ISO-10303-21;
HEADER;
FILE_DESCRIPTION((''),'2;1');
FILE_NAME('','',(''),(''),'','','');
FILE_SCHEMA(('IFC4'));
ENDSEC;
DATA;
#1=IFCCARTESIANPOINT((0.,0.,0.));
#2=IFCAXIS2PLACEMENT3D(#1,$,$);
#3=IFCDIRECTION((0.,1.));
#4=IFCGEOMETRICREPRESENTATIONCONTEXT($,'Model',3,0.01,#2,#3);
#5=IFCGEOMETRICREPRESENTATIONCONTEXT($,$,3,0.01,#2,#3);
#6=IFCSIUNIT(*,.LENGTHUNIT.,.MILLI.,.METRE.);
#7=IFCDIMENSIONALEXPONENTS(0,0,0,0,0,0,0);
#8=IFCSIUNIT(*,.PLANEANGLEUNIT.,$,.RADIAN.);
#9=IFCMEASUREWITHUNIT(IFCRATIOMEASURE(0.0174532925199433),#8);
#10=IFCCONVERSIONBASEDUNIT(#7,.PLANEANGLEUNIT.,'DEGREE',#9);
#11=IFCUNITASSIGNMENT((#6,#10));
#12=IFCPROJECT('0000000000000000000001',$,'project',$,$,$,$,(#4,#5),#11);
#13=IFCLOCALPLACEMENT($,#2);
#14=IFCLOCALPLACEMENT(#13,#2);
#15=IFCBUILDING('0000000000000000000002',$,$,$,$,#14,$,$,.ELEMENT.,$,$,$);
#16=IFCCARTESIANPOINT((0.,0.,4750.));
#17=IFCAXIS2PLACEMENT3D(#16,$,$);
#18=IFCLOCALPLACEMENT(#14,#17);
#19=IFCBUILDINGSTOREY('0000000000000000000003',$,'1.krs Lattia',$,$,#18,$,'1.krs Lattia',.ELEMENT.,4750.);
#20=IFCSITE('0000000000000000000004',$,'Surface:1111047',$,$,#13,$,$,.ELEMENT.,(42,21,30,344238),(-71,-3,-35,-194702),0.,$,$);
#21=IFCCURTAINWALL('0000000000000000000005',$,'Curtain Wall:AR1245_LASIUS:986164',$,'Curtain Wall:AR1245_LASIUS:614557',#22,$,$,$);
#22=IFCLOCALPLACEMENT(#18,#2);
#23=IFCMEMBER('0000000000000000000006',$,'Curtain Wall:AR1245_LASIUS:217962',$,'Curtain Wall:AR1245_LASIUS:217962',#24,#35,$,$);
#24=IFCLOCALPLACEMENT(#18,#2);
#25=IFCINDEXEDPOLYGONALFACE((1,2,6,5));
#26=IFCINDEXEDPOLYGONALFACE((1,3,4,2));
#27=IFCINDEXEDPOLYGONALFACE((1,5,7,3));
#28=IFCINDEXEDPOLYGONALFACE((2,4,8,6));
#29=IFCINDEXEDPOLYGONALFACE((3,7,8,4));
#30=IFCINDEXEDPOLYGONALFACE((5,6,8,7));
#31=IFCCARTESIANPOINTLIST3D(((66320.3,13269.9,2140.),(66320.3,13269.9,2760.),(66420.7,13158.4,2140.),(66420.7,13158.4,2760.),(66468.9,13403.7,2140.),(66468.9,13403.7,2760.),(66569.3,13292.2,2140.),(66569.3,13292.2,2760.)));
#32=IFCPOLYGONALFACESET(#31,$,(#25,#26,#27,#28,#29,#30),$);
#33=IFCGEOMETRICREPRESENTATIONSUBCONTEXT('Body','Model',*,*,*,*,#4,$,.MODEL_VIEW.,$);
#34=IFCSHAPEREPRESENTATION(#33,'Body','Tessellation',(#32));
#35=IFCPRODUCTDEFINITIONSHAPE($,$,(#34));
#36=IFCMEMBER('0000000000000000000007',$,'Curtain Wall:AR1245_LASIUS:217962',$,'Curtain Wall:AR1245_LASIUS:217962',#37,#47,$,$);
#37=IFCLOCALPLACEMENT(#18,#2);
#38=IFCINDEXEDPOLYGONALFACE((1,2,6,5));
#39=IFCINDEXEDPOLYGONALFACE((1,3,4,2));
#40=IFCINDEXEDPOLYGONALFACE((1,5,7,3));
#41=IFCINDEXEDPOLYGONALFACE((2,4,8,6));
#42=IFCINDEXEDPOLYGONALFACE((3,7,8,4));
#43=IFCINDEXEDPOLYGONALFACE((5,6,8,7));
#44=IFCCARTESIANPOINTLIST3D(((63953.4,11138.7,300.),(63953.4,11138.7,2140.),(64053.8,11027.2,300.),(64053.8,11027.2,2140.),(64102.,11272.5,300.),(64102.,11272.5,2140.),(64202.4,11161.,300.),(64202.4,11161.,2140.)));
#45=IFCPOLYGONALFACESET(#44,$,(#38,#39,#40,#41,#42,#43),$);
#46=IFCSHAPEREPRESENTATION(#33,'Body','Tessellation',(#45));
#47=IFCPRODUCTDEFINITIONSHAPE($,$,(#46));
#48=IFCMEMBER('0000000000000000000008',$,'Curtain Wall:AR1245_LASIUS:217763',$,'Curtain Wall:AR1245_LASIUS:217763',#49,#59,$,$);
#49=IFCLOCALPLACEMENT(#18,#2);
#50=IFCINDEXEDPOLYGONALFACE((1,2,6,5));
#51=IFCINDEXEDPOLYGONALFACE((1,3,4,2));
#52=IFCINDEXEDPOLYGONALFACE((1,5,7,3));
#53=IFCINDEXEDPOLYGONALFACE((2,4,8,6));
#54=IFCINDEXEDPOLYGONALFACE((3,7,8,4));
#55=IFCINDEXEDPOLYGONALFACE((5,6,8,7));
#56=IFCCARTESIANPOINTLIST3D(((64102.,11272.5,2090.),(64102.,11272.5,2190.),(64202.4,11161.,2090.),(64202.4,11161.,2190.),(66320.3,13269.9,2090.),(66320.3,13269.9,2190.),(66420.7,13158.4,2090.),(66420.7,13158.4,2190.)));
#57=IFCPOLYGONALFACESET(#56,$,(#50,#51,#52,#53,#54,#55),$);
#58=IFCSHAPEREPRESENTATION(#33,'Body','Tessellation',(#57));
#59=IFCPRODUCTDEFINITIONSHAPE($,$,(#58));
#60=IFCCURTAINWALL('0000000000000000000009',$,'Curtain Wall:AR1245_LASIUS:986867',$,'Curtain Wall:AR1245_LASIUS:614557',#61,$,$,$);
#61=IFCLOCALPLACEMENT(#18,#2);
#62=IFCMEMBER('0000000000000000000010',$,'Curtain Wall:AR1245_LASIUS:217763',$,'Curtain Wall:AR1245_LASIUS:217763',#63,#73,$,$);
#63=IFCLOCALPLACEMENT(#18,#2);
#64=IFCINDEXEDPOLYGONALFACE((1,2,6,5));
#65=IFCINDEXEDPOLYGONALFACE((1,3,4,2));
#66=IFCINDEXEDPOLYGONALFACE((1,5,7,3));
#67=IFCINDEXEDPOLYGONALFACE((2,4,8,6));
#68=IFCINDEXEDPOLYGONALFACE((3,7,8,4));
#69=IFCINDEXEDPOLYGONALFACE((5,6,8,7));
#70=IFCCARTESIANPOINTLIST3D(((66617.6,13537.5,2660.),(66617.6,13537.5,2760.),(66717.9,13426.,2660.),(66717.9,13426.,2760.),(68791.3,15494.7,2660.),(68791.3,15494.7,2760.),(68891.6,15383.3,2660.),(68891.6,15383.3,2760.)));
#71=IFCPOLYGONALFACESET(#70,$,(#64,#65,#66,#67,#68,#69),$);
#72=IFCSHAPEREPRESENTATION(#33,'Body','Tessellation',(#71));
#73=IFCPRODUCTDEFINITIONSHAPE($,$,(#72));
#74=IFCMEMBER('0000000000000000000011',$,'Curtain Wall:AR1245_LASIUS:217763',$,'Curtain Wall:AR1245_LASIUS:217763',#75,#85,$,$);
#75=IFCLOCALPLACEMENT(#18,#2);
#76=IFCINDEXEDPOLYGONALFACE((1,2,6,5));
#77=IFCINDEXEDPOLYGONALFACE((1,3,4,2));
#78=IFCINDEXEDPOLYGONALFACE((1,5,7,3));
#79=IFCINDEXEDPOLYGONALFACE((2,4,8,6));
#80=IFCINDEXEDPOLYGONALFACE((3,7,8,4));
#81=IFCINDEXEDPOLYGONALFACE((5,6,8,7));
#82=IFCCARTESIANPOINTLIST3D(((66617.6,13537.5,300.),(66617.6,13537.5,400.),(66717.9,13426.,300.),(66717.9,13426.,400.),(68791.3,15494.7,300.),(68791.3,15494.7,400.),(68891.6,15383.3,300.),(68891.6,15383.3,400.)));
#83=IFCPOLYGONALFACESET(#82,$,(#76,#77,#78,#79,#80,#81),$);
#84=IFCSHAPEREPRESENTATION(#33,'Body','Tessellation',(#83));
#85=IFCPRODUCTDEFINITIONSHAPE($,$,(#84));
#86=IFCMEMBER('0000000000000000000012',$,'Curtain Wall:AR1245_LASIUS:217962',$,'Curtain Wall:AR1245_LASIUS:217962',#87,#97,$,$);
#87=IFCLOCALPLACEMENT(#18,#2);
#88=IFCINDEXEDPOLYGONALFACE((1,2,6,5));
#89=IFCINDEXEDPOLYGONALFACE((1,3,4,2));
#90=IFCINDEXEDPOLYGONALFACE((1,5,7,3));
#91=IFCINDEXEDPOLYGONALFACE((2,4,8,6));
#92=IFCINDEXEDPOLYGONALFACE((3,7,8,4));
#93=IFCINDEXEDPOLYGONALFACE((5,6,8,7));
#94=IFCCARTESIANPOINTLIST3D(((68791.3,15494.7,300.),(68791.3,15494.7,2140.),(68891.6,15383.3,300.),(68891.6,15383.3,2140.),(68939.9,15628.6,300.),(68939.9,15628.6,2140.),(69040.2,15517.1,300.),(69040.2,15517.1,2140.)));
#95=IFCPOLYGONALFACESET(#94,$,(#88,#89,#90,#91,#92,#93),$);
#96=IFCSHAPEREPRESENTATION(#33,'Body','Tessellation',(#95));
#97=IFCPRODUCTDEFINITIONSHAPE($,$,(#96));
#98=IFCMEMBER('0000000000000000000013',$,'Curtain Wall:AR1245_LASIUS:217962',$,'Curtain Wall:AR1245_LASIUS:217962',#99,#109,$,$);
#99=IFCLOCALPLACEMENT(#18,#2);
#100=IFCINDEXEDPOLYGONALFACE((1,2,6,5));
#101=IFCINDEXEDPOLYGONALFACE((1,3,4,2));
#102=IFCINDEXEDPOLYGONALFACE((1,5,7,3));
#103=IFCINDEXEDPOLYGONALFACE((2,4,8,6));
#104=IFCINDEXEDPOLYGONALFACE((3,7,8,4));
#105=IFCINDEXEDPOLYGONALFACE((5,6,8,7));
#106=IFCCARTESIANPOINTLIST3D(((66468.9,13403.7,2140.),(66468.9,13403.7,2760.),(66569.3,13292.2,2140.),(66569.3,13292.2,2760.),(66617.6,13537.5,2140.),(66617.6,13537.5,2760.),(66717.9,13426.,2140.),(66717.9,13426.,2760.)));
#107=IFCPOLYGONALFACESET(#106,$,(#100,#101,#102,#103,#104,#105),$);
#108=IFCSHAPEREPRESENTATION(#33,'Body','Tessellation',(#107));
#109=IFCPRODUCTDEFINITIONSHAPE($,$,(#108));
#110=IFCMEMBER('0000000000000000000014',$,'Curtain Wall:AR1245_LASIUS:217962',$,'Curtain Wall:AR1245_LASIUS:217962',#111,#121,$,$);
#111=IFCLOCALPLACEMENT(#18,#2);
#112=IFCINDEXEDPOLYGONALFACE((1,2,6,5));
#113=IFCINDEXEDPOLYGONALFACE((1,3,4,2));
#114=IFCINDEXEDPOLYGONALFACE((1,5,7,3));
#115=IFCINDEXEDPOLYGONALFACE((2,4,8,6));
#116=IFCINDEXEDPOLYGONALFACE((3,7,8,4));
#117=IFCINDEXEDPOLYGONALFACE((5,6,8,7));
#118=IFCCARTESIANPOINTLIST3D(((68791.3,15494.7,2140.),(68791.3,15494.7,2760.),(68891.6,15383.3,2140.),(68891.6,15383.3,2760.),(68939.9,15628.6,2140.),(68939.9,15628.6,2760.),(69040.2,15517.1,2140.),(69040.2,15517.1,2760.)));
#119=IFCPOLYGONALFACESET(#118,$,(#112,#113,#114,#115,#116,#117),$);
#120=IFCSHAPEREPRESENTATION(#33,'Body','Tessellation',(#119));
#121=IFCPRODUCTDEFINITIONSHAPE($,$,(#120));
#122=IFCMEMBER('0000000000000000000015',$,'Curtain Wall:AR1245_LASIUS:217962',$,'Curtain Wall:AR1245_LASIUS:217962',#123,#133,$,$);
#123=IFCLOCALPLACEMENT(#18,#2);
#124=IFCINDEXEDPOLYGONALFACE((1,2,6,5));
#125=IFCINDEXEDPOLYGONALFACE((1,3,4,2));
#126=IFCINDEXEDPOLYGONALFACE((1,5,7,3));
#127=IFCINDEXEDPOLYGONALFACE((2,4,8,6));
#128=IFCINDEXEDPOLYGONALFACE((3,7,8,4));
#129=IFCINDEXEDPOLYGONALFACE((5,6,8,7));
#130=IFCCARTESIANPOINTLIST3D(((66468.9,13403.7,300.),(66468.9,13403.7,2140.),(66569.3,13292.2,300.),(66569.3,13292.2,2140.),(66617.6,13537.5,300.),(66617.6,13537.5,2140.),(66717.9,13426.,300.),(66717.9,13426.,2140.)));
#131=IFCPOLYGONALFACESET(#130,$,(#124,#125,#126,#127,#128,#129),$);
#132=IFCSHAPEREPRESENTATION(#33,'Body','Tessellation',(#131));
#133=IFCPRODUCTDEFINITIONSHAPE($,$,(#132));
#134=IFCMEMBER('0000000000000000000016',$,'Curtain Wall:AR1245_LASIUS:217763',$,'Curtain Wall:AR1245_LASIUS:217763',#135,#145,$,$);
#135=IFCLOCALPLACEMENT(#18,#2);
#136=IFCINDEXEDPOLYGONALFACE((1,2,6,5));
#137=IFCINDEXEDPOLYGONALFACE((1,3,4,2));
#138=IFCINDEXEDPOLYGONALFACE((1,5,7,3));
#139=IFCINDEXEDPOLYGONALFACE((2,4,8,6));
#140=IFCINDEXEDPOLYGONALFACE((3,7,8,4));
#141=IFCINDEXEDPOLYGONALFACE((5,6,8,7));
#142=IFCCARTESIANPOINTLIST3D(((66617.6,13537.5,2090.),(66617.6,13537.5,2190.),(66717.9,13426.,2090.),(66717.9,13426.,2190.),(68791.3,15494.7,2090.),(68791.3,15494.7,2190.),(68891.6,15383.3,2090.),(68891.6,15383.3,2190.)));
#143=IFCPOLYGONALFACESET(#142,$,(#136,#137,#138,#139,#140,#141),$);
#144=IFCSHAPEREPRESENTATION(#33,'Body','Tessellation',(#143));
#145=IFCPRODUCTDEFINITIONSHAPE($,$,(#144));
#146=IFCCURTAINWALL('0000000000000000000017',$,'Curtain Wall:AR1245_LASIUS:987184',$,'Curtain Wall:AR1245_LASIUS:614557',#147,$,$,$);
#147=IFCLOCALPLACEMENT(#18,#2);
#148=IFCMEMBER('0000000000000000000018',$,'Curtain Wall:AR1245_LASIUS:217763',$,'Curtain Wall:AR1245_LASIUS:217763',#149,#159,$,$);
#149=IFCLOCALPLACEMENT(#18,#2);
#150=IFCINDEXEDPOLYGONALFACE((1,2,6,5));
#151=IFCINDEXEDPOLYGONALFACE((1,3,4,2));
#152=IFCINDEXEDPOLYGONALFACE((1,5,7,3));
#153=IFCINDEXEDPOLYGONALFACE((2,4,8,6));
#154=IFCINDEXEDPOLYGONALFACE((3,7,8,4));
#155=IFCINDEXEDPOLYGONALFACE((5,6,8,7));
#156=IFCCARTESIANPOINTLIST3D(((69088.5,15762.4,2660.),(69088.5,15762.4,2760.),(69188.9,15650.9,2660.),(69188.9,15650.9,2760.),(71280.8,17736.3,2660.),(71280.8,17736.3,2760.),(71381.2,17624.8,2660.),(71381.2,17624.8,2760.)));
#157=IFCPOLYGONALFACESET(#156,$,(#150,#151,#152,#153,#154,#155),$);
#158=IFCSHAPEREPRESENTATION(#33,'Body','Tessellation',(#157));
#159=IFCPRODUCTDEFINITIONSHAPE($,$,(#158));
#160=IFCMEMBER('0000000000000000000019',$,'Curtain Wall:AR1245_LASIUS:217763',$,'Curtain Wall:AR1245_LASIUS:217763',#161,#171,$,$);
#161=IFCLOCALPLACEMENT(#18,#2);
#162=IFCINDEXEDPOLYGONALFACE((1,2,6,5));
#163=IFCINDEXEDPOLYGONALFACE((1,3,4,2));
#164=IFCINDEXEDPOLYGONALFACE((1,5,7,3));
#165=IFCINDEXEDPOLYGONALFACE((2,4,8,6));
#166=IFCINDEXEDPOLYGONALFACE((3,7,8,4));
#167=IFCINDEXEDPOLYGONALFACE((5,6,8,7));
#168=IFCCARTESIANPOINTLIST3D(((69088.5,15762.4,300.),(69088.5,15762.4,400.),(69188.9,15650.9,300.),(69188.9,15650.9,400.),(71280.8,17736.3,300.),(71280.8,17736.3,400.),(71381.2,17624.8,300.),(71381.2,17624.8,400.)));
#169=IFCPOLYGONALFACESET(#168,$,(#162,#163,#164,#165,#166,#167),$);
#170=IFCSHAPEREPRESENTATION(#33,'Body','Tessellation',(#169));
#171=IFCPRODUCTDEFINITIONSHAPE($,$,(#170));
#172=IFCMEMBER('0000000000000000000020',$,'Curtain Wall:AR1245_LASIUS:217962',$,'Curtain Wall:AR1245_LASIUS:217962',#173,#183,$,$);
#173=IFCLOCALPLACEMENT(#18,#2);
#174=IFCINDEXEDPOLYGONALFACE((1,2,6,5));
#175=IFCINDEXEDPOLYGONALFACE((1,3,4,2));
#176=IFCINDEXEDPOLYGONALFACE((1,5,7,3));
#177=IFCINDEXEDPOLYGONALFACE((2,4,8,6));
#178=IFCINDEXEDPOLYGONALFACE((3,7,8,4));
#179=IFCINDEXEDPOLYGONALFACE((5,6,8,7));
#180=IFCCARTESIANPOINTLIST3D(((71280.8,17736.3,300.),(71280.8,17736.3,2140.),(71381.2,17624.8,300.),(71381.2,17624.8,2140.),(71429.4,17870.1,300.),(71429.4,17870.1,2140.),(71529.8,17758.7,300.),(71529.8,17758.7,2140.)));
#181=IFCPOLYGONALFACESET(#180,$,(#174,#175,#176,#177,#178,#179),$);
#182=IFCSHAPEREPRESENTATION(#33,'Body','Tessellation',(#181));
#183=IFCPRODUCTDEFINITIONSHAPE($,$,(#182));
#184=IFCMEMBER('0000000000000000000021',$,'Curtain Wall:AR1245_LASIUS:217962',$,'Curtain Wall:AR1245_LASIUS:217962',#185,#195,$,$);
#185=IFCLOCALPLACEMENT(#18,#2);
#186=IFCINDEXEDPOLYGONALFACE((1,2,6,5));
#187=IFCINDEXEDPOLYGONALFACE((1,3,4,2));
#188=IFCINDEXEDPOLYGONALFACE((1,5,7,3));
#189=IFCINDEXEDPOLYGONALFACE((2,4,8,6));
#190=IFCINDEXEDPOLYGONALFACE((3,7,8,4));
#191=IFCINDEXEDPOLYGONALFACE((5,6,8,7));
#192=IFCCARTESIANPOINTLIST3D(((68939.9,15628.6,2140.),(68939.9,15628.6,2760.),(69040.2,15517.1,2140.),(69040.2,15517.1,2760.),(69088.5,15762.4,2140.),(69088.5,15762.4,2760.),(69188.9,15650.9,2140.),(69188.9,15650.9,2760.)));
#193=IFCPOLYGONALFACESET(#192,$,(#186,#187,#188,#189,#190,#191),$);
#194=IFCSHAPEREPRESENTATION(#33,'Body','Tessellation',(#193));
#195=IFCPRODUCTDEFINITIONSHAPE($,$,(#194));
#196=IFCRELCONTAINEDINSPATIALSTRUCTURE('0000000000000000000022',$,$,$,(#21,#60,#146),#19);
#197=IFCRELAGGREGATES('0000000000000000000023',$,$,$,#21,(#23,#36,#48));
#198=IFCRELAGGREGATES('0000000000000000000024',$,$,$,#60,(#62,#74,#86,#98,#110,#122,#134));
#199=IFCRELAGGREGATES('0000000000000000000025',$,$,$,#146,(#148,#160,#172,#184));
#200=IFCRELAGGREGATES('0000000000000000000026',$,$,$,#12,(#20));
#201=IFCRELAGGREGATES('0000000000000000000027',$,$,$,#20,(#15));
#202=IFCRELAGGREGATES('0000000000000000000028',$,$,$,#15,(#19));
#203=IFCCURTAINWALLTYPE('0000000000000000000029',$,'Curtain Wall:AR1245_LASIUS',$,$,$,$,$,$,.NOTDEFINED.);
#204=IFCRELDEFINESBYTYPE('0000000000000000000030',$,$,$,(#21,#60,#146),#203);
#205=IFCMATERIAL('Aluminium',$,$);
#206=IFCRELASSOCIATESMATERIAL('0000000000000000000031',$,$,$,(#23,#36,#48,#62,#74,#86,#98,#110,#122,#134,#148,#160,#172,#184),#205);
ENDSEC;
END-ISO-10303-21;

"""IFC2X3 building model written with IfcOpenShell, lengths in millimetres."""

from ifc_helpers import new_model, entity, si_unit, converted_unit, direction, frame, frame_2d, origin, place, context, subcontext, project, spatial, rectangle, extrude, material, type_object, element, aggregate, save


model = new_model("IFC2X3")

# Units and contexts
model_context = context("Model", 3, precision=0.01, world=origin(), true_north=direction((0.0, 1.0)))
context_of_model = context(None, 3, precision=0.01, world=origin(), true_north=direction((0.0, 1.0)))
body_context = subcontext(model_context, "Body", "Model", "MODEL_VIEW")
ifc_project = project(units=[si_unit("LENGTHUNIT", "METRE", prefix="MILLI"), converted_unit("PLANEANGLEUNIT", "DEGREE", entity("IfcRatioMeasure", 0.0174532925199433), si_unit("PLANEANGLEUNIT", "RADIAN"), dimensions=[0, 0, 0, 0, 0, 0, 0])], contexts=[model_context, context_of_model])

# Site, building, storey
site_placement = place(None, origin())
site = spatial("IfcSite", under=ifc_project, at=site_placement, Name="Surface:1111047", CompositionType="ELEMENT", RefLatitude=(42, 21, 30, 344238), RefLongitude=(-71, -3, -35, -194702), RefElevation=0.0)
building_placement = place(site_placement, origin())
building = spatial("IfcBuilding", under=site, at=building_placement, CompositionType="ELEMENT")
storey_placement = place(building_placement, frame((0.0, 0.0, 4750.0)))
storey = spatial("IfcBuildingStorey", under=building, at=storey_placement, Name="1.krs Lattia", LongName="1.krs Lattia", CompositionType="ELEMENT", Elevation=4750.0)

# Curtain walls, members
curtain_wall_type_1 = type_object("IfcCurtainWallType", Name="Curtain Wall:AR1245_LASIUS", PredefinedType="NOTDEFINED")
curtain_wall_1_placement = place(storey_placement, frame((0.0, 0.0, -4750.0)))
curtain_wall_1 = element("IfcCurtainWall", 1, at=curtain_wall_1_placement, inside=storey, type_object=curtain_wall_type_1, Name="Curtain Wall:AR1245_LASIUS:986164", ObjectType="Curtain Wall:AR1245_LASIUS:614557")
ifc_material_1 = material(Name="Aluminium")
member_1_placement = place(curtain_wall_1_placement, frame((0.0, 0.0, 4750.0)))
member_1 = element("IfcMember", 2, at=member_1_placement, material=ifc_material_1, Name="Curtain Wall:AR1245_LASIUS:217962", ObjectType="Curtain Wall:AR1245_LASIUS:217962", context=body_context, shape_type="SweptSolid", body=[
    extrude(rectangle(XDim=200.0, YDim=150.0, at=frame_2d((0.0, 0.0), x_axis=(1.0, 0.0))), frame((66444.8, 13281.0, 2140.0), z_axis=(0.0, 0.0, 1.0), x_axis=(0.743145, 0.669131, 0.0)), (0.0, 0.0, 1.0), 620.0),
])
member_2_placement = place(curtain_wall_1_placement, frame((0.0, 0.0, 4750.0)))
member_2 = element("IfcMember", 3, at=member_2_placement, material=ifc_material_1, Name="Curtain Wall:AR1245_LASIUS:217962", ObjectType="Curtain Wall:AR1245_LASIUS:217962", context=body_context, shape_type="SweptSolid", body=[
    extrude(rectangle(XDim=150.0, YDim=200.0, at=frame_2d((0.0, 0.0), x_axis=(1.0, 0.0))), frame((64077.9, 11149.9, 2140.0), z_axis=(0.0, 0.0, -1.0), x_axis=(0.669131, -0.743145, 0.0)), (0.0, 0.0, 1.0), 1840.0),
])
member_3_placement = place(curtain_wall_1_placement, frame((0.0, 0.0, 4750.0)))
member_3 = element("IfcMember", 4, at=member_3_placement, material=ifc_material_1, Name="Curtain Wall:AR1245_LASIUS:217763", ObjectType="Curtain Wall:AR1245_LASIUS:217763", context=body_context, shape_type="SweptSolid", body=[
    extrude(rectangle(XDim=100.0, YDim=150.0, at=frame_2d((0.0, 0.0), x_axis=(1.0, 0.0))), frame((66370.5, 13214.1, 2140.0), z_axis=(-0.743145, -0.669131, 0.0), x_axis=(0.0, 0.0, -1.0)), (0.0, 0.0, 1.0), 2985.0),
])
aggregate(curtain_wall_1, [member_1, member_2, member_3])
curtain_wall_2_placement = place(storey_placement, frame((0.0, 0.0, -4750.0)))
curtain_wall_2 = element("IfcCurtainWall", 5, at=curtain_wall_2_placement, inside=storey, type_object=curtain_wall_type_1, Name="Curtain Wall:AR1245_LASIUS:986867", ObjectType="Curtain Wall:AR1245_LASIUS:614557")
member_4_placement = place(curtain_wall_2_placement, frame((0.0, 0.0, 4750.0)))
member_4 = element("IfcMember", 6, at=member_4_placement, material=ifc_material_1, Name="Curtain Wall:AR1245_LASIUS:217763", ObjectType="Curtain Wall:AR1245_LASIUS:217763", context=body_context, shape_type="SweptSolid", body=[
    extrude(rectangle(XDim=100.0, YDim=150.0, at=frame_2d((0.0, 0.0), x_axis=(1.0, 0.0))), frame((68841.4, 15439.0, 2710.0), z_axis=(-0.743145, -0.669131, 0.0), x_axis=(0.0, 0.0, -1.0)), (0.0, 0.0, 1.0), 2925.0),
])
member_5_placement = place(curtain_wall_2_placement, frame((0.0, 0.0, 4750.0)))
member_5 = element("IfcMember", 7, at=member_5_placement, material=ifc_material_1, Name="Curtain Wall:AR1245_LASIUS:217763", ObjectType="Curtain Wall:AR1245_LASIUS:217763", context=body_context, shape_type="SweptSolid", body=[
    extrude(rectangle(XDim=100.0, YDim=150.0, at=frame_2d((0.0, 0.0), x_axis=(1.0, 0.0))), frame((66667.7, 13481.8, 350.0), z_axis=(0.743145, 0.669131, 0.0), x_axis=(0.0, 0.0, -1.0)), (0.0, 0.0, 1.0), 2925.0),
])
member_6_placement = place(curtain_wall_2_placement, frame((0.0, 0.0, 4750.0)))
member_6 = element("IfcMember", 8, at=member_6_placement, material=ifc_material_1, Name="Curtain Wall:AR1245_LASIUS:217962", ObjectType="Curtain Wall:AR1245_LASIUS:217962", context=body_context, shape_type="SweptSolid", body=[
    extrude(rectangle(XDim=200.0, YDim=150.0, at=frame_2d((0.0, 0.0), x_axis=(1.0, 0.0))), frame((68915.7, 15505.9, 300.0), z_axis=(0.0, 0.0, 1.0), x_axis=(0.743145, 0.669131, 0.0)), (0.0, 0.0, 1.0), 1840.0),
])
member_7_placement = place(curtain_wall_2_placement, frame((0.0, 0.0, 4750.0)))
member_7 = element("IfcMember", 9, at=member_7_placement, material=ifc_material_1, Name="Curtain Wall:AR1245_LASIUS:217962", ObjectType="Curtain Wall:AR1245_LASIUS:217962", context=body_context, shape_type="SweptSolid", body=[
    extrude(rectangle(XDim=150.0, YDim=200.0, at=frame_2d((0.0, 0.0), x_axis=(1.0, 0.0))), frame((66593.4, 13414.9, 2760.0), z_axis=(0.0, 0.0, -1.0), x_axis=(0.669131, -0.743145, 0.0)), (0.0, 0.0, 1.0), 620.0),
])
member_8_placement = place(curtain_wall_2_placement, frame((0.0, 0.0, 4750.0)))
member_8 = element("IfcMember", 10, at=member_8_placement, material=ifc_material_1, Name="Curtain Wall:AR1245_LASIUS:217962", ObjectType="Curtain Wall:AR1245_LASIUS:217962", context=body_context, shape_type="SweptSolid", body=[
    extrude(rectangle(XDim=200.0, YDim=150.0, at=frame_2d((0.0, 0.0), x_axis=(1.0, 0.0))), frame((68915.7, 15505.9, 2140.0), z_axis=(0.0, 0.0, 1.0), x_axis=(0.743145, 0.669131, 0.0)), (0.0, 0.0, 1.0), 620.0),
])
member_9_placement = place(curtain_wall_2_placement, frame((0.0, 0.0, 4750.0)))
member_9 = element("IfcMember", 11, at=member_9_placement, material=ifc_material_1, Name="Curtain Wall:AR1245_LASIUS:217962", ObjectType="Curtain Wall:AR1245_LASIUS:217962", context=body_context, shape_type="SweptSolid", body=[
    extrude(rectangle(XDim=150.0, YDim=200.0, at=frame_2d((0.0, 0.0), x_axis=(1.0, 0.0))), frame((66593.4, 13414.9, 2140.0), z_axis=(0.0, 0.0, -1.0), x_axis=(0.669131, -0.743145, 0.0)), (0.0, 0.0, 1.0), 1840.0),
])
member_10_placement = place(curtain_wall_2_placement, frame((0.0, 0.0, 4750.0)))
member_10 = element("IfcMember", 12, at=member_10_placement, material=ifc_material_1, Name="Curtain Wall:AR1245_LASIUS:217763", ObjectType="Curtain Wall:AR1245_LASIUS:217763", context=body_context, shape_type="SweptSolid", body=[
    extrude(rectangle(XDim=100.0, YDim=150.0, at=frame_2d((0.0, 0.0), x_axis=(1.0, 0.0))), frame((68841.4, 15439.0, 2140.0), z_axis=(-0.743145, -0.669131, 0.0), x_axis=(0.0, 0.0, -1.0)), (0.0, 0.0, 1.0), 2925.0),
])
aggregate(curtain_wall_2, [member_4, member_5, member_6, member_7, member_8, member_9, member_10])
curtain_wall_3_placement = place(storey_placement, frame((0.0, 0.0, -4750.0)))
curtain_wall_3 = element("IfcCurtainWall", 13, at=curtain_wall_3_placement, inside=storey, type_object=curtain_wall_type_1, Name="Curtain Wall:AR1245_LASIUS:987184", ObjectType="Curtain Wall:AR1245_LASIUS:614557")
member_11_placement = place(curtain_wall_3_placement, frame((0.0, 0.0, 4750.0)))
member_11 = element("IfcMember", 14, at=member_11_placement, material=ifc_material_1, Name="Curtain Wall:AR1245_LASIUS:217763", ObjectType="Curtain Wall:AR1245_LASIUS:217763", context=body_context, shape_type="SweptSolid", body=[
    extrude(rectangle(XDim=100.0, YDim=150.0, at=frame_2d((0.0, 0.0), x_axis=(1.0, 0.0))), frame((71331.0, 17680.6, 2710.0), z_axis=(-0.743145, -0.669131, 0.0), x_axis=(0.0, 0.0, -1.0)), (0.0, 0.0, 1.0), 2950.0),
])
member_12_placement = place(curtain_wall_3_placement, frame((0.0, 0.0, 4750.0)))
member_12 = element("IfcMember", 15, at=member_12_placement, material=ifc_material_1, Name="Curtain Wall:AR1245_LASIUS:217763", ObjectType="Curtain Wall:AR1245_LASIUS:217763", context=body_context, shape_type="SweptSolid", body=[
    extrude(rectangle(XDim=100.0, YDim=150.0, at=frame_2d((0.0, 0.0), x_axis=(1.0, 0.0))), frame((69138.7, 15706.6, 350.0), z_axis=(0.743145, 0.669131, 0.0), x_axis=(0.0, 0.0, -1.0)), (0.0, 0.0, 1.0), 2950.0),
])
member_13_placement = place(curtain_wall_3_placement, frame((0.0, 0.0, 4750.0)))
member_13 = element("IfcMember", 16, at=member_13_placement, material=ifc_material_1, Name="Curtain Wall:AR1245_LASIUS:217962", ObjectType="Curtain Wall:AR1245_LASIUS:217962", context=body_context, shape_type="SweptSolid", body=[
    extrude(rectangle(XDim=200.0, YDim=150.0, at=frame_2d((0.0, 0.0), x_axis=(1.0, 0.0))), frame((71405.3, 17747.5, 300.0), z_axis=(0.0, 0.0, 1.0), x_axis=(0.743145, 0.669131, 0.0)), (0.0, 0.0, 1.0), 1840.0),
])
member_14_placement = place(curtain_wall_3_placement, frame((0.0, 0.0, 4750.0)))
member_14 = element("IfcMember", 17, at=member_14_placement, material=ifc_material_1, Name="Curtain Wall:AR1245_LASIUS:217962", ObjectType="Curtain Wall:AR1245_LASIUS:217962", context=body_context, shape_type="SweptSolid", body=[
    extrude(rectangle(XDim=150.0, YDim=200.0, at=frame_2d((0.0, 0.0), x_axis=(1.0, 0.0))), frame((69064.4, 15639.7, 2760.0), z_axis=(0.0, 0.0, -1.0), x_axis=(0.669131, -0.743145, 0.0)), (0.0, 0.0, 1.0), 620.0),
])
aggregate(curtain_wall_3, [member_11, member_12, member_13, member_14])

save(model, "model.ifc")
